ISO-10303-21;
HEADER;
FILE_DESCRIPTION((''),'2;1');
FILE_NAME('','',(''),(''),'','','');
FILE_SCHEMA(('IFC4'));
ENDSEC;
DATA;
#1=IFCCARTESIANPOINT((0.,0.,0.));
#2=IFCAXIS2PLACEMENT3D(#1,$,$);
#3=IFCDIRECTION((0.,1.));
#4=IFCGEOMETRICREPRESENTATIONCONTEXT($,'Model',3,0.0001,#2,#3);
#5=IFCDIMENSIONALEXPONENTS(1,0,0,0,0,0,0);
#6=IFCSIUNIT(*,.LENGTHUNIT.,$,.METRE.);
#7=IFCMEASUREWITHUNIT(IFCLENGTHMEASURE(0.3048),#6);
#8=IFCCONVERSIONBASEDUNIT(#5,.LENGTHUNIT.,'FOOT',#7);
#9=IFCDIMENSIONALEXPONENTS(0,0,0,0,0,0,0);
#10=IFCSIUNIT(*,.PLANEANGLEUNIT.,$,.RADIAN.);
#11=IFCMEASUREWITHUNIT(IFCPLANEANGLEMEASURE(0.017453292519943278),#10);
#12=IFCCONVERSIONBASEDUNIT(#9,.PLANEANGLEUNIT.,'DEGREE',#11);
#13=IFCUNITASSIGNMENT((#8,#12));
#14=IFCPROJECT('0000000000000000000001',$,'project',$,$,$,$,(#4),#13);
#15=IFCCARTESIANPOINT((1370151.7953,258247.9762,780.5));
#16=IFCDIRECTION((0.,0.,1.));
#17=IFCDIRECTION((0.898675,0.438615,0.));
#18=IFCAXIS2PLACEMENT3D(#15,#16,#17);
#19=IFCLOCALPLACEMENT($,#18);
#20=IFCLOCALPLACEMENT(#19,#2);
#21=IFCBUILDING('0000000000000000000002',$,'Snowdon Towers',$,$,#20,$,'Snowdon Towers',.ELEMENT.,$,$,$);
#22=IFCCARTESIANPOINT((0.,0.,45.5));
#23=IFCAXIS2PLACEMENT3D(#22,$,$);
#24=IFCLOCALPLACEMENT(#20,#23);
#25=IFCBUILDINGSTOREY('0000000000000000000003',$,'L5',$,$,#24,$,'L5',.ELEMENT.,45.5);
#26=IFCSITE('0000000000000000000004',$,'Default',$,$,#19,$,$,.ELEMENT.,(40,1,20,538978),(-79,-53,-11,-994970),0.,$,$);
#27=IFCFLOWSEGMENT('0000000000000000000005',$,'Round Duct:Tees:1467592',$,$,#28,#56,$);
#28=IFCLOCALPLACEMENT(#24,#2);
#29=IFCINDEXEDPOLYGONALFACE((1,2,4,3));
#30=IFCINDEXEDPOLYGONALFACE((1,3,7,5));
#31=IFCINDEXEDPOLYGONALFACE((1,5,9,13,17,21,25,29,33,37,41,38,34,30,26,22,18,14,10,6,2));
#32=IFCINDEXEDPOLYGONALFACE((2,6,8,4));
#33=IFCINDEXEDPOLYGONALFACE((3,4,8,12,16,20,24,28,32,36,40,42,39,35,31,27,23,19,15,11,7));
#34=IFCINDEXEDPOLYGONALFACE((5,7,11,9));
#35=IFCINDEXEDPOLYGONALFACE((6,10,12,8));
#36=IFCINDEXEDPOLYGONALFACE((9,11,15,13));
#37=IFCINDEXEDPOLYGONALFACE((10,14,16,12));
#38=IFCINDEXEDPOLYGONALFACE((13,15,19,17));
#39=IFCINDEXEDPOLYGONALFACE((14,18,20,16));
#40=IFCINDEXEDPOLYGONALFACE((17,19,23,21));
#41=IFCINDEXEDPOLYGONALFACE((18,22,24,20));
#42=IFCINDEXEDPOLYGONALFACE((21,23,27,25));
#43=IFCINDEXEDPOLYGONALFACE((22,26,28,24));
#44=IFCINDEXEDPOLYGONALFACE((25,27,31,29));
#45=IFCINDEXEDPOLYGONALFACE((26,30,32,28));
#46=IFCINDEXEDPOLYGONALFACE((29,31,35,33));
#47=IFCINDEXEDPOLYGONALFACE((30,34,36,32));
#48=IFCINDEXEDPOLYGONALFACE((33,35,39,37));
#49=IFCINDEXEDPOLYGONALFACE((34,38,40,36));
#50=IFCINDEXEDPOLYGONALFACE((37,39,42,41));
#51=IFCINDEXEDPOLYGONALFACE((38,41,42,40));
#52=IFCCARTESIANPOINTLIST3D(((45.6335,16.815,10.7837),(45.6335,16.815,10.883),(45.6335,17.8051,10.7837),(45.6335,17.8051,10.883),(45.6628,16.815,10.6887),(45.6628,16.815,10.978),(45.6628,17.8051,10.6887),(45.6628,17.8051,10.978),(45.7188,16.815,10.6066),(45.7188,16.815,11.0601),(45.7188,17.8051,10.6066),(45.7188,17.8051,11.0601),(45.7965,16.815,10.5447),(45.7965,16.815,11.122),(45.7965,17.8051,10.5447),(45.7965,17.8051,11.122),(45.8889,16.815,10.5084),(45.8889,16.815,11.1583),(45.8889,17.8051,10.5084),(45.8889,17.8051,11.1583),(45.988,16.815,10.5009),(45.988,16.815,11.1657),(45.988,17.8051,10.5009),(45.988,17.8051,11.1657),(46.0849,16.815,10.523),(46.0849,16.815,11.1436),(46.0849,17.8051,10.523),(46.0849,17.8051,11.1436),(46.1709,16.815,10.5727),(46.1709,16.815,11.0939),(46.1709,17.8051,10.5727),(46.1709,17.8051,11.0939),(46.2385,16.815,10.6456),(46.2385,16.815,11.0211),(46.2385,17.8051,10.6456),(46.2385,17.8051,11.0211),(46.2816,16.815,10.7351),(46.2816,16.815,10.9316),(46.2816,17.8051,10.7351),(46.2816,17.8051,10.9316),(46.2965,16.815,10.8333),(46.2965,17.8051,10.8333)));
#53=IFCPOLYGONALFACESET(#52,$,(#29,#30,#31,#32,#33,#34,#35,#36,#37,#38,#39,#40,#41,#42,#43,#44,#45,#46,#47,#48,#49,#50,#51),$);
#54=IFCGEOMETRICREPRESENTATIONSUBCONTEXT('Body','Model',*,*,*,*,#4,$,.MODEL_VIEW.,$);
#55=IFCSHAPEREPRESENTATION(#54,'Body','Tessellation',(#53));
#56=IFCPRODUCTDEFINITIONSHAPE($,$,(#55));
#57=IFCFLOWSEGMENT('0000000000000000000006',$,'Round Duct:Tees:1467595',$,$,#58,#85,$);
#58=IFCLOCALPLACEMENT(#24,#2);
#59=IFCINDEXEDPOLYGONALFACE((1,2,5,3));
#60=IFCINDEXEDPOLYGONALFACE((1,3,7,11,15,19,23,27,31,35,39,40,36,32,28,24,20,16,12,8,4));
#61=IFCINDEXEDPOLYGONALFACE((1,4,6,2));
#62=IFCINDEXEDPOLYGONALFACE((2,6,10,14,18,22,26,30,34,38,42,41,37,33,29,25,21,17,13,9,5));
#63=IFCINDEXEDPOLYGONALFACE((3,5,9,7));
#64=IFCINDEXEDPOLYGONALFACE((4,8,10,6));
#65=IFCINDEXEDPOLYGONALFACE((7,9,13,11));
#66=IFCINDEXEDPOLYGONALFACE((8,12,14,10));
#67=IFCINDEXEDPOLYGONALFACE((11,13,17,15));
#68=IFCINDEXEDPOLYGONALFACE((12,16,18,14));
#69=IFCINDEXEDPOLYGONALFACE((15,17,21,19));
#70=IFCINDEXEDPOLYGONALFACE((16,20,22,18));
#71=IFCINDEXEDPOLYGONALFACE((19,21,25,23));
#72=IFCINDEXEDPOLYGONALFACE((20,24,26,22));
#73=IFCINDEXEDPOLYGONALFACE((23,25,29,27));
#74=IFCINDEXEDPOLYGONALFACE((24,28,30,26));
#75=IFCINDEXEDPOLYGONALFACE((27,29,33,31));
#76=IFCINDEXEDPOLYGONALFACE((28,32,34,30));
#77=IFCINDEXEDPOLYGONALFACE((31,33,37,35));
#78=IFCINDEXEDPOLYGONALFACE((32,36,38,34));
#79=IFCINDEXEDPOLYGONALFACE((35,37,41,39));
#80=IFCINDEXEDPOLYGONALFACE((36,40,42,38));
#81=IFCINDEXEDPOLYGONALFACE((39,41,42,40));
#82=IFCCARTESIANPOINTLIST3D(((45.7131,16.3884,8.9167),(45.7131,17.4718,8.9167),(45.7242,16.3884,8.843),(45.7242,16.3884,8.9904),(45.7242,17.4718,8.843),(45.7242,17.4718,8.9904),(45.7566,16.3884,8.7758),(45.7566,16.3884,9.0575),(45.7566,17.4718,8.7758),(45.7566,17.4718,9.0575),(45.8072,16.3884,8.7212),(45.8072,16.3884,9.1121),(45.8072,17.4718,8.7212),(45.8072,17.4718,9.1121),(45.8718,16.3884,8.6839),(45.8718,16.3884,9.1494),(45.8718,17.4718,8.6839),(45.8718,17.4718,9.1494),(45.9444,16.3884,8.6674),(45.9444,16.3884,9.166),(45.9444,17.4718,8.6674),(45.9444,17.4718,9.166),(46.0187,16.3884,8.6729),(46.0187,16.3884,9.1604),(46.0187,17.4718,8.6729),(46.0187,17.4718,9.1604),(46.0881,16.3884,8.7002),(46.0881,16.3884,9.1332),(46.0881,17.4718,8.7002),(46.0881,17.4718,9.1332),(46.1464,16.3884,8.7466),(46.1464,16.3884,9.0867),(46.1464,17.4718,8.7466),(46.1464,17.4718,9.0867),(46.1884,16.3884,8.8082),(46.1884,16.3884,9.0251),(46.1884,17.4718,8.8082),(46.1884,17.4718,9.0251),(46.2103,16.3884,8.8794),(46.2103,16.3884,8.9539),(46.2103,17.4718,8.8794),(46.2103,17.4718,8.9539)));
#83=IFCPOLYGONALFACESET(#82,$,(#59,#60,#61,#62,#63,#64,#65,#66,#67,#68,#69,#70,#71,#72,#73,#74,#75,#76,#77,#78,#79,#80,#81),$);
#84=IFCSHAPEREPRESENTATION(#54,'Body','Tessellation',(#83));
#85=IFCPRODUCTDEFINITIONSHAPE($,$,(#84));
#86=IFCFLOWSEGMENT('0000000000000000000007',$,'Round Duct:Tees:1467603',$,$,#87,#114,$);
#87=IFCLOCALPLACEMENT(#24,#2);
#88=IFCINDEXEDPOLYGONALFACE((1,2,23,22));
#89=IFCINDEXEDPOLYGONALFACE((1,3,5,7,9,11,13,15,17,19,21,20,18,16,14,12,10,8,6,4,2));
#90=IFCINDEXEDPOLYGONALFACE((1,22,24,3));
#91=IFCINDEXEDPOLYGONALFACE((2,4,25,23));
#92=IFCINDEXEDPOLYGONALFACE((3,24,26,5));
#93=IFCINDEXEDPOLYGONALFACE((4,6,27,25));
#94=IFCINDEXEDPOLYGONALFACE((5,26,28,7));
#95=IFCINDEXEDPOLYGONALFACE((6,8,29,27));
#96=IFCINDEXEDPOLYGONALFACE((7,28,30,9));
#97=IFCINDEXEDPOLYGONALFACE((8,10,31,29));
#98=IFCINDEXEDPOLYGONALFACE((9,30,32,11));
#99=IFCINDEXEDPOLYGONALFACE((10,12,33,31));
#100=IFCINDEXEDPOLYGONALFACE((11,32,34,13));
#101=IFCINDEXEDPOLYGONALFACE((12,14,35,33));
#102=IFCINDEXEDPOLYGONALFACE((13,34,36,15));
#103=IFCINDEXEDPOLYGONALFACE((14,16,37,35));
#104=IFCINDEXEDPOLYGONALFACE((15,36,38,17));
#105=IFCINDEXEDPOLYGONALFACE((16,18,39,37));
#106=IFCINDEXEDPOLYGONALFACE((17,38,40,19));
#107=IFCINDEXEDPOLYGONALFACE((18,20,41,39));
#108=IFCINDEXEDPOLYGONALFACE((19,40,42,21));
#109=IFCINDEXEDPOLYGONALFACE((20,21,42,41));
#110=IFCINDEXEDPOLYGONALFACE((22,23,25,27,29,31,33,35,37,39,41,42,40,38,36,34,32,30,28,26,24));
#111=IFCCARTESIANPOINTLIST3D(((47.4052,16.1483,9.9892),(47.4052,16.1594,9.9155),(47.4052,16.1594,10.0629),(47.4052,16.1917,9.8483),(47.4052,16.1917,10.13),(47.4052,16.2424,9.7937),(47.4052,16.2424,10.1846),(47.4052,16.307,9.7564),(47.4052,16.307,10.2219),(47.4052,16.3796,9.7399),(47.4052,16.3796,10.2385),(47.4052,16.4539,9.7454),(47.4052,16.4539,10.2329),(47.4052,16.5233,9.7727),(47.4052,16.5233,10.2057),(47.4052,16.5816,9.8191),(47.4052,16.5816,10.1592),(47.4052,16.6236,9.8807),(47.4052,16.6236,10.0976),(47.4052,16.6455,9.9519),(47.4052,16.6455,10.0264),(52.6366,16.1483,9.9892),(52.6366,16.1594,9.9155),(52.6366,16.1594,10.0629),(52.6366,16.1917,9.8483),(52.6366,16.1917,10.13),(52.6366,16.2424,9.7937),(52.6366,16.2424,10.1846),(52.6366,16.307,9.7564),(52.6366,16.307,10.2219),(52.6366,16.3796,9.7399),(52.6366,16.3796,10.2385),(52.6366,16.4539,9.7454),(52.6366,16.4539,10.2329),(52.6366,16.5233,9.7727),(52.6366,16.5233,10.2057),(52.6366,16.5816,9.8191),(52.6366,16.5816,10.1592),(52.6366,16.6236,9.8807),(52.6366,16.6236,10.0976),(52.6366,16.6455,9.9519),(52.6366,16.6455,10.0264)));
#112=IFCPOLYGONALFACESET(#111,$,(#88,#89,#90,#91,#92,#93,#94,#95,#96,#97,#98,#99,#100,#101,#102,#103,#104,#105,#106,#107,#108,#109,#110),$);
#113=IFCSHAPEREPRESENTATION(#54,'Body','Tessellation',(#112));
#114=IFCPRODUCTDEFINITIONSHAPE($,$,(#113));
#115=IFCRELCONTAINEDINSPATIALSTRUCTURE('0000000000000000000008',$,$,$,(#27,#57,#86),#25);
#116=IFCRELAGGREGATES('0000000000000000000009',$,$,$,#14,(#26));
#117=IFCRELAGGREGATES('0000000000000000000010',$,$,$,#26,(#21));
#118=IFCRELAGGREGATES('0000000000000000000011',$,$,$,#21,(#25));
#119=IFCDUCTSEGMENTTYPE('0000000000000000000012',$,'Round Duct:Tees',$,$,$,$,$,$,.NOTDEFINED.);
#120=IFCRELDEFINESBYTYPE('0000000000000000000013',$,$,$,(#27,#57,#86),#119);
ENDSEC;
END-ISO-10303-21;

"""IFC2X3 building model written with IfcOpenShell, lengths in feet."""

from ifc_helpers import new_model, entity, si_unit, converted_unit, direction, frame, frame_2d, origin, origin_2d_with_axis, place, context, subcontext, project, spatial, circle, extrude, type_object, element, save


model = new_model("IFC2X3")

# Units and contexts
model_context = context("Model", 3, precision=0.0001, world=origin(), true_north=direction((0.0, 1.0)))
body_context = subcontext(model_context, "Body", "Model", "MODEL_VIEW")
ifc_project = project(units=[converted_unit("LENGTHUNIT", "FOOT", entity("IfcLengthMeasure", 0.3048), si_unit("LENGTHUNIT", "METRE"), dimensions=[1, 0, 0, 0, 0, 0, 0]), converted_unit("PLANEANGLEUNIT", "DEGREE", entity("IfcPlaneAngleMeasure", 0.017453292519943278), si_unit("PLANEANGLEUNIT", "RADIAN"), dimensions=[0, 0, 0, 0, 0, 0, 0])], contexts=[model_context])

# Site, building, storey
site_placement = place(None, frame((1370151.7953, 258247.9762, 780.5), z_axis=(0.0, 0.0, 1.0), x_axis=(0.898675, 0.438615, 0.0)))
site = spatial("IfcSite", under=ifc_project, at=site_placement, Name="Default", CompositionType="ELEMENT", RefLatitude=(40, 1, 20, 538978), RefLongitude=(-79, -53, -11, -994970), RefElevation=0.0)
building_placement = place(site_placement, origin())
building = spatial("IfcBuilding", under=site, at=building_placement, Name="Snowdon Towers", LongName="Snowdon Towers", CompositionType="ELEMENT")
storey_placement = place(building_placement, frame((0.0, 0.0, 45.5)))
storey = spatial("IfcBuildingStorey", under=building, at=storey_placement, Name="L5", LongName="L5", CompositionType="ELEMENT", Elevation=45.5)

# Flow segments
duct_segment_type = type_object("IfcDuctSegmentType", Name="Round Duct:Tees", PredefinedType="NOTDEFINED")
flow_segment_1_placement = place(storey_placement, origin())
element("IfcFlowSegment", 1, at=flow_segment_1_placement, inside=storey, type_object=duct_segment_type, Name="Round Duct:Tees:1467592", context=body_context, shape_type="SweptSolid", body=[
    extrude(circle(Radius=0.3333, at=frame_2d((0.0, 0.0), x_axis=(1.0, 0.0))), frame((45.9631, 16.815, 10.8333), z_axis=(0.0, 1.0, 0.0), x_axis=(1.0, 0.0, 0.0)), (0.0, 0.0, 1.0), 0.9901),
])
flow_segment_2_placement = place(storey_placement, origin())
element("IfcFlowSegment", 2, at=flow_segment_2_placement, inside=storey, type_object=duct_segment_type, Name="Round Duct:Tees:1467595", context=body_context, shape_type="SweptSolid", body=[
    extrude(circle(Radius=0.25, at=origin_2d_with_axis()), frame((45.9631, 16.3884, 8.9167), z_axis=(0.0, 1.0, 0.0), x_axis=(-1.0, 0.0, 0.0)), (0.0, 0.0, 1.0), 1.0833),
])
flow_segment_3_placement = place(storey_placement, origin())
element("IfcFlowSegment", 3, at=flow_segment_3_placement, inside=storey, type_object=duct_segment_type, Name="Round Duct:Tees:1467603", context=body_context, shape_type="SweptSolid", body=[
    extrude(circle(Radius=0.25, at=frame_2d((0.0, 0.0), x_axis=(1.0, 0.0))), frame((47.4052, 16.3983, 9.9892), z_axis=(1.0, 0.0, 0.0), x_axis=(0.0, -1.0, 0.0)), (0.0, 0.0, 1.0), 5.2314),
])

save(model, "model.ifc")
